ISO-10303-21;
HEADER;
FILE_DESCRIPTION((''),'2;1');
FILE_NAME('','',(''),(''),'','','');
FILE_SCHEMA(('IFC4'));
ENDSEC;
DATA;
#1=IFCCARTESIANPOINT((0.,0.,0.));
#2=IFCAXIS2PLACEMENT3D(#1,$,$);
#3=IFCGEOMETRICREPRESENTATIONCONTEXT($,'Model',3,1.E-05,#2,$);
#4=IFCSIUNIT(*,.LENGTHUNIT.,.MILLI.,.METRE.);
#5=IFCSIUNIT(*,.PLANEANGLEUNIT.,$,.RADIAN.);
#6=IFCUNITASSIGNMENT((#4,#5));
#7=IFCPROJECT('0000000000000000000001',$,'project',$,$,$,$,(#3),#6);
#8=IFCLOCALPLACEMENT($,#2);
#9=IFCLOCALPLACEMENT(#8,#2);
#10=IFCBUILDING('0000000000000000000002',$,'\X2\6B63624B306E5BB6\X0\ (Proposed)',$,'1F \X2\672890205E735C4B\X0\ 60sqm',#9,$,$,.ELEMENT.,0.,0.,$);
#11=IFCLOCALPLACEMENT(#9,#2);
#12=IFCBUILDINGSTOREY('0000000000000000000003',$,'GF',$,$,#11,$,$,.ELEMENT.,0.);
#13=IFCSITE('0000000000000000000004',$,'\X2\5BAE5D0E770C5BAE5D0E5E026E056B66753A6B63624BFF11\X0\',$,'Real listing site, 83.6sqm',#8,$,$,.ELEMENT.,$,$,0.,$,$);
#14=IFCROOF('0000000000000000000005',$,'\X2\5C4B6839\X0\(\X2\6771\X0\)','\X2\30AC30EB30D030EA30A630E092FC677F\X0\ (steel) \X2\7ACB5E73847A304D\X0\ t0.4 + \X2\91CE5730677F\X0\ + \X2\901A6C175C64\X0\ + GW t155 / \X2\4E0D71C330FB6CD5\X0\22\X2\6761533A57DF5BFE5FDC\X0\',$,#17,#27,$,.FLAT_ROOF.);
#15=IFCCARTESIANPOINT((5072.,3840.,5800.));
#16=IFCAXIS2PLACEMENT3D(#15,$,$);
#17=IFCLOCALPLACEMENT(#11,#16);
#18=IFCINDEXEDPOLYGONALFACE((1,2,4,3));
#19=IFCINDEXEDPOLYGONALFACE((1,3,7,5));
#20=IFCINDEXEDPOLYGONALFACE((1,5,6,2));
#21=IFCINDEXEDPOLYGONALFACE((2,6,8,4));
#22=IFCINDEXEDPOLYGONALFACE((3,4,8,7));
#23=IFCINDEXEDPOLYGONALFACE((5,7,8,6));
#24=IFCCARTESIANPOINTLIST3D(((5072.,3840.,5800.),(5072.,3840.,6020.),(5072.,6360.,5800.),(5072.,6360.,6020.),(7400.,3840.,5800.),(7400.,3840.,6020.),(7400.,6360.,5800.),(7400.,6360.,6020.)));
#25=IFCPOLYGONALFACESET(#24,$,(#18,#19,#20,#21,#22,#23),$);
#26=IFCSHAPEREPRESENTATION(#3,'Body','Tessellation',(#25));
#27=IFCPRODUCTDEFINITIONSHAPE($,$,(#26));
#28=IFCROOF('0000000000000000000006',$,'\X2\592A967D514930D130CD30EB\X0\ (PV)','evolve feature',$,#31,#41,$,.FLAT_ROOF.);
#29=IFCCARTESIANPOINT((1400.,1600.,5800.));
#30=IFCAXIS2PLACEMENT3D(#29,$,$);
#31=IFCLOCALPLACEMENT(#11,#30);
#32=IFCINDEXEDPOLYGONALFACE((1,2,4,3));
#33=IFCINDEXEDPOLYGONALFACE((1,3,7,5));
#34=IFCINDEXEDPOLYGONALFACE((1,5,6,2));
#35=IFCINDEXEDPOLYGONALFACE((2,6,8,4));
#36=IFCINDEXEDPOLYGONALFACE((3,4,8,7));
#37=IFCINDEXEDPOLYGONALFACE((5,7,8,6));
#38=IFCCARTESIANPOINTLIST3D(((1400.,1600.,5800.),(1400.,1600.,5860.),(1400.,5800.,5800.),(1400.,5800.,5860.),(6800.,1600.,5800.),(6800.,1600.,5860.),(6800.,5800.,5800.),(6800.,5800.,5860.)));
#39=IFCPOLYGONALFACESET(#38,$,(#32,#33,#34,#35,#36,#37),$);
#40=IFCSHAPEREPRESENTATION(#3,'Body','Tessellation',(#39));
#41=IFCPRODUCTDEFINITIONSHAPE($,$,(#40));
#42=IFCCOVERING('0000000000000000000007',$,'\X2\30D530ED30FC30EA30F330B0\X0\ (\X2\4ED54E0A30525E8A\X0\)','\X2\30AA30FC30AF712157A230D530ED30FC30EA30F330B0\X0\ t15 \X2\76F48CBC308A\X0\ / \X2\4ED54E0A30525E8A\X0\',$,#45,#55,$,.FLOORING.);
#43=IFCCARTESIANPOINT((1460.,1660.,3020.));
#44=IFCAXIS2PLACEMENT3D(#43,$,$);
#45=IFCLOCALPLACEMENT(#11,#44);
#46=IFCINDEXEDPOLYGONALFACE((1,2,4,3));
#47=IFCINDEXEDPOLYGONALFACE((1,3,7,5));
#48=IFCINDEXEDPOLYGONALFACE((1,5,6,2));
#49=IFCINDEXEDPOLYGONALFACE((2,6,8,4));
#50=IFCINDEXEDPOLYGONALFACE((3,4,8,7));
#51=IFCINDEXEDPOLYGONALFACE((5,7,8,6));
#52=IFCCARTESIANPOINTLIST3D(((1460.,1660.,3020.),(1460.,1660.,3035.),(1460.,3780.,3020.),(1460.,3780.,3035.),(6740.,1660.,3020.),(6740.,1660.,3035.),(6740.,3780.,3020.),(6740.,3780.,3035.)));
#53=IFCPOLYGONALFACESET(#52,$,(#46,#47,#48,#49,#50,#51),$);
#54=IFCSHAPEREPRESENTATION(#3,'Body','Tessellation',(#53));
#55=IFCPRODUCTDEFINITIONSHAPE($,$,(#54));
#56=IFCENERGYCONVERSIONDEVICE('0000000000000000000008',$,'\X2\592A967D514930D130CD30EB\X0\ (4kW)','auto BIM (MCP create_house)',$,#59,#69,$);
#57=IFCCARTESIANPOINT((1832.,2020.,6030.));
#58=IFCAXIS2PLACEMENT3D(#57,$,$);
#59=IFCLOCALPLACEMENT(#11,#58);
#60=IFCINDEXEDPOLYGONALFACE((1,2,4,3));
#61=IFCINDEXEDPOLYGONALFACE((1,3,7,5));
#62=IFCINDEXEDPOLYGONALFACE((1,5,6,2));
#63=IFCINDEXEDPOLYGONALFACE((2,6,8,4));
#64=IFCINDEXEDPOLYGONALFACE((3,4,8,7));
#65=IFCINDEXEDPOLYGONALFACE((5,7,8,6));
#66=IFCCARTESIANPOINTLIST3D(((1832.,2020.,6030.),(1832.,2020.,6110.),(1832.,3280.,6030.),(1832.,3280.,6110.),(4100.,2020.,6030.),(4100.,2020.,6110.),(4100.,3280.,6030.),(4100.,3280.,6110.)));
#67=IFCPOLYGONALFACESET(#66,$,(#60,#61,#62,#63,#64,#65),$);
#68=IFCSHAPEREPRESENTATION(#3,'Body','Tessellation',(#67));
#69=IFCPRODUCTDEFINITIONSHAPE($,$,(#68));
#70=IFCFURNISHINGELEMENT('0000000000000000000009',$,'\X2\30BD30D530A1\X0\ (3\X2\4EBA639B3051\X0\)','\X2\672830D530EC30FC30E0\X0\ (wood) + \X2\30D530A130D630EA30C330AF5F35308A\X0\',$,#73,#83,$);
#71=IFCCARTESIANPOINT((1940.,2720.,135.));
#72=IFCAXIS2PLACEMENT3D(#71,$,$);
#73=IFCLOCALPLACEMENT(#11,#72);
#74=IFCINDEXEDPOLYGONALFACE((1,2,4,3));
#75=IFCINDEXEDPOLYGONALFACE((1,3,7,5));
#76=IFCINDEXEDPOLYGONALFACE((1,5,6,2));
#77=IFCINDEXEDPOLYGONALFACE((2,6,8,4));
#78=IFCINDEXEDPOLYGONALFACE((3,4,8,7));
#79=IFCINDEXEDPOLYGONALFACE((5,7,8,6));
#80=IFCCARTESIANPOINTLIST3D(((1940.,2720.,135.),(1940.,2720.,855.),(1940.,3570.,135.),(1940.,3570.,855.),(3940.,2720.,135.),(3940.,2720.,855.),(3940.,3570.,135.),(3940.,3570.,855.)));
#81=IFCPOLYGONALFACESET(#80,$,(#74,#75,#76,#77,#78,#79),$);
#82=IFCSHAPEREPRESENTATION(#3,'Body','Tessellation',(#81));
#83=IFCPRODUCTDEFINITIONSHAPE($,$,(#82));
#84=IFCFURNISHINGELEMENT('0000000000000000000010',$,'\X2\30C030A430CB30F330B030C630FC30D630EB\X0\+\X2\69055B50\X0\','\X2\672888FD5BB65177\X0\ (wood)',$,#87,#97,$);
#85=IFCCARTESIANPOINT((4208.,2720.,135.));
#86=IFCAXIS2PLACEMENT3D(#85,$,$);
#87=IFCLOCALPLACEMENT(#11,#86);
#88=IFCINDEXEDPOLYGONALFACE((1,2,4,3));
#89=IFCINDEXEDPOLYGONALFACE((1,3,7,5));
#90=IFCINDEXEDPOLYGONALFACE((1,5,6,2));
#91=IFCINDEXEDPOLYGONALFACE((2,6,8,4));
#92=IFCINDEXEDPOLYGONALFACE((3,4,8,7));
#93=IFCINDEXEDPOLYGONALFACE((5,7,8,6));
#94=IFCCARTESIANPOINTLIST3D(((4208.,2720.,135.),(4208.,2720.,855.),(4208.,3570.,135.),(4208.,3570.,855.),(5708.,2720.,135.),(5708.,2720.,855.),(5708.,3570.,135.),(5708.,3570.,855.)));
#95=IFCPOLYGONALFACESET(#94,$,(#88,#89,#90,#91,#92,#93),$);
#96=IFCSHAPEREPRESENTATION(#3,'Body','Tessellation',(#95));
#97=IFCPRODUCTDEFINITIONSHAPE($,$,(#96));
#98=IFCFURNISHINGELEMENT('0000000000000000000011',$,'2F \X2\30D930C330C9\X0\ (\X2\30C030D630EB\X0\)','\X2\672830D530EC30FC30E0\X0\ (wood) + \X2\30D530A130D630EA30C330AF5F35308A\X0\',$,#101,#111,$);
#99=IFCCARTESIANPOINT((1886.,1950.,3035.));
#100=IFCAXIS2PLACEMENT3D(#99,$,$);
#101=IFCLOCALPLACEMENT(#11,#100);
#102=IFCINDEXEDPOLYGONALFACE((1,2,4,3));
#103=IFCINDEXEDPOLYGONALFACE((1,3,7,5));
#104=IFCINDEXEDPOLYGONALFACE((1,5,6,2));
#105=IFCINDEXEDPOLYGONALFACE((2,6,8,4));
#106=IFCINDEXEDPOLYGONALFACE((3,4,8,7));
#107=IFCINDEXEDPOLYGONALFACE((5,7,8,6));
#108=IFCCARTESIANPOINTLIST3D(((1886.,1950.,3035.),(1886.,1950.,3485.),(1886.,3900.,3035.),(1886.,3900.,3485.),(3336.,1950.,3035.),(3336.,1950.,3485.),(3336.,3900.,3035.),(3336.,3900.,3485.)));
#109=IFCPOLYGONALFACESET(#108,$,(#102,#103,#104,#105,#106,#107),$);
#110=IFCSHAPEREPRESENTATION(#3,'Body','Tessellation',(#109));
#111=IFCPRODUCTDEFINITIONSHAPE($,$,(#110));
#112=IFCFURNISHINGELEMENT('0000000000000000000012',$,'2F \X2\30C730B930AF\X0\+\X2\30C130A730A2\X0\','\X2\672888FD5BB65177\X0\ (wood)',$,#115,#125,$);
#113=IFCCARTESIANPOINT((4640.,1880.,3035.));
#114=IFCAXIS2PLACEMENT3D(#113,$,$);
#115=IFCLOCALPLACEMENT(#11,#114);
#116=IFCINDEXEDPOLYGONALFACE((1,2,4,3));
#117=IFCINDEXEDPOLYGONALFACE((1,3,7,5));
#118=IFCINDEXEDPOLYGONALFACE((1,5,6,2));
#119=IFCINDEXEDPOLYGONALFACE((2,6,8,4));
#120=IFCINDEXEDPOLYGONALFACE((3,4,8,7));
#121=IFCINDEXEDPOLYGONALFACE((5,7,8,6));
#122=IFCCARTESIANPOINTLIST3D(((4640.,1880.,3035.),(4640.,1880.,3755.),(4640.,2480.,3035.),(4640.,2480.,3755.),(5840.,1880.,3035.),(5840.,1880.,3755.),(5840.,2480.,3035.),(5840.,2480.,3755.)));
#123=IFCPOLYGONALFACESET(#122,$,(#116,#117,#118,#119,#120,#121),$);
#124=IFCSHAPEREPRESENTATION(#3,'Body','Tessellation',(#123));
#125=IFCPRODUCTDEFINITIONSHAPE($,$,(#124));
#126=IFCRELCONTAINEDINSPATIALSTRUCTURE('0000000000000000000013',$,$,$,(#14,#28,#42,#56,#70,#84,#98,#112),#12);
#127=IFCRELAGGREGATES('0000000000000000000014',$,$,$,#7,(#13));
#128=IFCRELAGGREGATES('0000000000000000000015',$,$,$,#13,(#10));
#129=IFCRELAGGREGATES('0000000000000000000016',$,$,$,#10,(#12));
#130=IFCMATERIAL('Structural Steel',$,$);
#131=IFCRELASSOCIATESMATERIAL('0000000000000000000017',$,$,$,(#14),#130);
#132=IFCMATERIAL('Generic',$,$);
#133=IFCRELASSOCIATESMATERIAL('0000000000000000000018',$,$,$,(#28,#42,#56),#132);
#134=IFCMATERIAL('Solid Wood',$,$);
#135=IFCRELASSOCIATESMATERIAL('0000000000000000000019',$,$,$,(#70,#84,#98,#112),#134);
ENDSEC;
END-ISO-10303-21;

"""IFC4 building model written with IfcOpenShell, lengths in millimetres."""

from ifc_helpers import new_model, si_unit, frame, frame_2d, origin, place, context, project, spatial, rectangle, extrude, material, element, save


model = new_model("IFC4")

# Units and contexts
model_context = context("Model", 3, precision=1e-05, world=origin())
ifc_project = project(units=[si_unit("LENGTHUNIT", "METRE", prefix="MILLI"), si_unit("PLANEANGLEUNIT", "RADIAN")], contexts=[model_context])

# Site, building, storey
site_placement = place(None, origin())
site = spatial("IfcSite", under=ifc_project, at=site_placement, Name="宮崎県宮崎市清武町正手１", ObjectType="Real listing site, 83.6sqm", CompositionType="ELEMENT", RefElevation=0.0)
building_placement = place(site_placement, origin())
building = spatial("IfcBuilding", under=site, at=building_placement, Name="正手の家 (Proposed)", ObjectType="1F 木造平屋 60sqm", CompositionType="ELEMENT", ElevationOfRefHeight=0.0, ElevationOfTerrain=0.0)
storey_placement = place(building_placement, origin())
storey = spatial("IfcBuildingStorey", under=building, at=storey_placement, Name="GF", CompositionType="ELEMENT", Elevation=0.0)

# Shared definitions
ifc_material_1 = material(Name="Solid Wood")

# Roofs
ifc_material_2 = material(Name="Structural Steel")
roof_1_placement = place(storey_placement, frame((5072.0, 3840.0, 5800.0)))
element("IfcRoof", 1, at=roof_1_placement, inside=storey, material=ifc_material_2, Name="屋根(東)", Description="ガルバリウム鋼板 (steel) 立平葺き t0.4 + 野地板 + 通気層 + GW t155 / 不燃・法22条区域対応", PredefinedType="FLAT_ROOF", context=model_context, shape_type="SweptSolid", body=[
    extrude(rectangle(XDim=2328.0, YDim=2520.0, at=frame_2d((1164.0, 1260.0))), frame((5072.0, 3840.0, 5800.0)), (0.0, 0.0, 1.0), 220.0),
])
ifc_material_3 = material(Name="Generic")
roof_2_placement = place(storey_placement, frame((1400.0, 1600.0, 5800.0)))
element("IfcRoof", 2, at=roof_2_placement, inside=storey, material=ifc_material_3, Name="太陽光パネル (PV)", Description="evolve feature", PredefinedType="FLAT_ROOF", context=model_context, shape_type="SweptSolid", body=[
    extrude(rectangle(XDim=5400.0, YDim=4200.0, at=frame_2d((2700.0, 2100.0))), frame((1400.0, 1600.0, 5800.0)), (0.0, 0.0, 1.0), 60.0),
])

# Covering
covering_placement = place(storey_placement, frame((1460.0, 1660.0, 3020.0)))
element("IfcCovering", 3, at=covering_placement, inside=storey, material=ifc_material_3, Name="フローリング (仕上げ床)", Description="オーク無垢フローリング t15 直貼り / 仕上げ床", PredefinedType="FLOORING", context=model_context, shape_type="SweptSolid", body=[
    extrude(rectangle(XDim=5280.0, YDim=2120.0, at=frame_2d((2640.0, 1060.0))), frame((1460.0, 1660.0, 3020.0)), (0.0, 0.0, 1.0), 15.0),
])

# Energy conversion device
energy_conversion_device_placement = place(storey_placement, frame((1832.0, 2020.0, 6030.0)))
element("IfcEnergyConversionDevice", 4, at=energy_conversion_device_placement, inside=storey, material=ifc_material_3, Name="太陽光パネル (4kW)", Description="auto BIM (MCP create_house)", context=model_context, shape_type="SweptSolid", body=[
    extrude(rectangle(XDim=2268.0, YDim=1260.0, at=frame_2d((1134.0, 630.0))), frame((1832.0, 2020.0, 6030.0)), (0.0, 0.0, 1.0), 80.0),
])

# Furnishing elements
furnishing_1_placement = place(storey_placement, frame((1940.0, 2720.0, 135.0)))
element("IfcFurnishingElement", 5, at=furnishing_1_placement, inside=storey, material=ifc_material_1, Name="ソファ (3人掛け)", Description="木フレーム (wood) + ファブリック張り", context=model_context, shape_type="SweptSolid", body=[
    extrude(rectangle(XDim=2000.0, YDim=850.0, at=frame_2d((1000.0, 425.0))), frame((1940.0, 2720.0, 135.0)), (0.0, 0.0, 1.0), 720.0),
])
furnishing_2_placement = place(storey_placement, frame((4208.0, 2720.0, 135.0)))
element("IfcFurnishingElement", 6, at=furnishing_2_placement, inside=storey, material=ifc_material_1, Name="ダイニングテーブル+椅子", Description="木製家具 (wood)", context=model_context, shape_type="SweptSolid", body=[
    extrude(rectangle(XDim=1500.0, YDim=850.0, at=frame_2d((750.0, 425.0))), frame((4208.0, 2720.0, 135.0)), (0.0, 0.0, 1.0), 720.0),
])
furnishing_3_placement = place(storey_placement, frame((1886.0, 1950.0, 3035.0)))
element("IfcFurnishingElement", 7, at=furnishing_3_placement, inside=storey, material=ifc_material_1, Name="2F ベッド (ダブル)", Description="木フレーム (wood) + ファブリック張り", context=model_context, shape_type="SweptSolid", body=[
    extrude(rectangle(XDim=1450.0, YDim=1950.0, at=frame_2d((725.0, 975.0))), frame((1886.0, 1950.0, 3035.0)), (0.0, 0.0, 1.0), 450.0),
])
furnishing_4_placement = place(storey_placement, frame((4640.0, 1880.0, 3035.0)))
element("IfcFurnishingElement", 8, at=furnishing_4_placement, inside=storey, material=ifc_material_1, Name="2F デスク+チェア", Description="木製家具 (wood)", context=model_context, shape_type="SweptSolid", body=[
    extrude(rectangle(XDim=1200.0, YDim=600.0, at=frame_2d((600.0, 300.0))), frame((4640.0, 1880.0, 3035.0)), (0.0, 0.0, 1.0), 720.0),
])

save(model, "model.ifc")
